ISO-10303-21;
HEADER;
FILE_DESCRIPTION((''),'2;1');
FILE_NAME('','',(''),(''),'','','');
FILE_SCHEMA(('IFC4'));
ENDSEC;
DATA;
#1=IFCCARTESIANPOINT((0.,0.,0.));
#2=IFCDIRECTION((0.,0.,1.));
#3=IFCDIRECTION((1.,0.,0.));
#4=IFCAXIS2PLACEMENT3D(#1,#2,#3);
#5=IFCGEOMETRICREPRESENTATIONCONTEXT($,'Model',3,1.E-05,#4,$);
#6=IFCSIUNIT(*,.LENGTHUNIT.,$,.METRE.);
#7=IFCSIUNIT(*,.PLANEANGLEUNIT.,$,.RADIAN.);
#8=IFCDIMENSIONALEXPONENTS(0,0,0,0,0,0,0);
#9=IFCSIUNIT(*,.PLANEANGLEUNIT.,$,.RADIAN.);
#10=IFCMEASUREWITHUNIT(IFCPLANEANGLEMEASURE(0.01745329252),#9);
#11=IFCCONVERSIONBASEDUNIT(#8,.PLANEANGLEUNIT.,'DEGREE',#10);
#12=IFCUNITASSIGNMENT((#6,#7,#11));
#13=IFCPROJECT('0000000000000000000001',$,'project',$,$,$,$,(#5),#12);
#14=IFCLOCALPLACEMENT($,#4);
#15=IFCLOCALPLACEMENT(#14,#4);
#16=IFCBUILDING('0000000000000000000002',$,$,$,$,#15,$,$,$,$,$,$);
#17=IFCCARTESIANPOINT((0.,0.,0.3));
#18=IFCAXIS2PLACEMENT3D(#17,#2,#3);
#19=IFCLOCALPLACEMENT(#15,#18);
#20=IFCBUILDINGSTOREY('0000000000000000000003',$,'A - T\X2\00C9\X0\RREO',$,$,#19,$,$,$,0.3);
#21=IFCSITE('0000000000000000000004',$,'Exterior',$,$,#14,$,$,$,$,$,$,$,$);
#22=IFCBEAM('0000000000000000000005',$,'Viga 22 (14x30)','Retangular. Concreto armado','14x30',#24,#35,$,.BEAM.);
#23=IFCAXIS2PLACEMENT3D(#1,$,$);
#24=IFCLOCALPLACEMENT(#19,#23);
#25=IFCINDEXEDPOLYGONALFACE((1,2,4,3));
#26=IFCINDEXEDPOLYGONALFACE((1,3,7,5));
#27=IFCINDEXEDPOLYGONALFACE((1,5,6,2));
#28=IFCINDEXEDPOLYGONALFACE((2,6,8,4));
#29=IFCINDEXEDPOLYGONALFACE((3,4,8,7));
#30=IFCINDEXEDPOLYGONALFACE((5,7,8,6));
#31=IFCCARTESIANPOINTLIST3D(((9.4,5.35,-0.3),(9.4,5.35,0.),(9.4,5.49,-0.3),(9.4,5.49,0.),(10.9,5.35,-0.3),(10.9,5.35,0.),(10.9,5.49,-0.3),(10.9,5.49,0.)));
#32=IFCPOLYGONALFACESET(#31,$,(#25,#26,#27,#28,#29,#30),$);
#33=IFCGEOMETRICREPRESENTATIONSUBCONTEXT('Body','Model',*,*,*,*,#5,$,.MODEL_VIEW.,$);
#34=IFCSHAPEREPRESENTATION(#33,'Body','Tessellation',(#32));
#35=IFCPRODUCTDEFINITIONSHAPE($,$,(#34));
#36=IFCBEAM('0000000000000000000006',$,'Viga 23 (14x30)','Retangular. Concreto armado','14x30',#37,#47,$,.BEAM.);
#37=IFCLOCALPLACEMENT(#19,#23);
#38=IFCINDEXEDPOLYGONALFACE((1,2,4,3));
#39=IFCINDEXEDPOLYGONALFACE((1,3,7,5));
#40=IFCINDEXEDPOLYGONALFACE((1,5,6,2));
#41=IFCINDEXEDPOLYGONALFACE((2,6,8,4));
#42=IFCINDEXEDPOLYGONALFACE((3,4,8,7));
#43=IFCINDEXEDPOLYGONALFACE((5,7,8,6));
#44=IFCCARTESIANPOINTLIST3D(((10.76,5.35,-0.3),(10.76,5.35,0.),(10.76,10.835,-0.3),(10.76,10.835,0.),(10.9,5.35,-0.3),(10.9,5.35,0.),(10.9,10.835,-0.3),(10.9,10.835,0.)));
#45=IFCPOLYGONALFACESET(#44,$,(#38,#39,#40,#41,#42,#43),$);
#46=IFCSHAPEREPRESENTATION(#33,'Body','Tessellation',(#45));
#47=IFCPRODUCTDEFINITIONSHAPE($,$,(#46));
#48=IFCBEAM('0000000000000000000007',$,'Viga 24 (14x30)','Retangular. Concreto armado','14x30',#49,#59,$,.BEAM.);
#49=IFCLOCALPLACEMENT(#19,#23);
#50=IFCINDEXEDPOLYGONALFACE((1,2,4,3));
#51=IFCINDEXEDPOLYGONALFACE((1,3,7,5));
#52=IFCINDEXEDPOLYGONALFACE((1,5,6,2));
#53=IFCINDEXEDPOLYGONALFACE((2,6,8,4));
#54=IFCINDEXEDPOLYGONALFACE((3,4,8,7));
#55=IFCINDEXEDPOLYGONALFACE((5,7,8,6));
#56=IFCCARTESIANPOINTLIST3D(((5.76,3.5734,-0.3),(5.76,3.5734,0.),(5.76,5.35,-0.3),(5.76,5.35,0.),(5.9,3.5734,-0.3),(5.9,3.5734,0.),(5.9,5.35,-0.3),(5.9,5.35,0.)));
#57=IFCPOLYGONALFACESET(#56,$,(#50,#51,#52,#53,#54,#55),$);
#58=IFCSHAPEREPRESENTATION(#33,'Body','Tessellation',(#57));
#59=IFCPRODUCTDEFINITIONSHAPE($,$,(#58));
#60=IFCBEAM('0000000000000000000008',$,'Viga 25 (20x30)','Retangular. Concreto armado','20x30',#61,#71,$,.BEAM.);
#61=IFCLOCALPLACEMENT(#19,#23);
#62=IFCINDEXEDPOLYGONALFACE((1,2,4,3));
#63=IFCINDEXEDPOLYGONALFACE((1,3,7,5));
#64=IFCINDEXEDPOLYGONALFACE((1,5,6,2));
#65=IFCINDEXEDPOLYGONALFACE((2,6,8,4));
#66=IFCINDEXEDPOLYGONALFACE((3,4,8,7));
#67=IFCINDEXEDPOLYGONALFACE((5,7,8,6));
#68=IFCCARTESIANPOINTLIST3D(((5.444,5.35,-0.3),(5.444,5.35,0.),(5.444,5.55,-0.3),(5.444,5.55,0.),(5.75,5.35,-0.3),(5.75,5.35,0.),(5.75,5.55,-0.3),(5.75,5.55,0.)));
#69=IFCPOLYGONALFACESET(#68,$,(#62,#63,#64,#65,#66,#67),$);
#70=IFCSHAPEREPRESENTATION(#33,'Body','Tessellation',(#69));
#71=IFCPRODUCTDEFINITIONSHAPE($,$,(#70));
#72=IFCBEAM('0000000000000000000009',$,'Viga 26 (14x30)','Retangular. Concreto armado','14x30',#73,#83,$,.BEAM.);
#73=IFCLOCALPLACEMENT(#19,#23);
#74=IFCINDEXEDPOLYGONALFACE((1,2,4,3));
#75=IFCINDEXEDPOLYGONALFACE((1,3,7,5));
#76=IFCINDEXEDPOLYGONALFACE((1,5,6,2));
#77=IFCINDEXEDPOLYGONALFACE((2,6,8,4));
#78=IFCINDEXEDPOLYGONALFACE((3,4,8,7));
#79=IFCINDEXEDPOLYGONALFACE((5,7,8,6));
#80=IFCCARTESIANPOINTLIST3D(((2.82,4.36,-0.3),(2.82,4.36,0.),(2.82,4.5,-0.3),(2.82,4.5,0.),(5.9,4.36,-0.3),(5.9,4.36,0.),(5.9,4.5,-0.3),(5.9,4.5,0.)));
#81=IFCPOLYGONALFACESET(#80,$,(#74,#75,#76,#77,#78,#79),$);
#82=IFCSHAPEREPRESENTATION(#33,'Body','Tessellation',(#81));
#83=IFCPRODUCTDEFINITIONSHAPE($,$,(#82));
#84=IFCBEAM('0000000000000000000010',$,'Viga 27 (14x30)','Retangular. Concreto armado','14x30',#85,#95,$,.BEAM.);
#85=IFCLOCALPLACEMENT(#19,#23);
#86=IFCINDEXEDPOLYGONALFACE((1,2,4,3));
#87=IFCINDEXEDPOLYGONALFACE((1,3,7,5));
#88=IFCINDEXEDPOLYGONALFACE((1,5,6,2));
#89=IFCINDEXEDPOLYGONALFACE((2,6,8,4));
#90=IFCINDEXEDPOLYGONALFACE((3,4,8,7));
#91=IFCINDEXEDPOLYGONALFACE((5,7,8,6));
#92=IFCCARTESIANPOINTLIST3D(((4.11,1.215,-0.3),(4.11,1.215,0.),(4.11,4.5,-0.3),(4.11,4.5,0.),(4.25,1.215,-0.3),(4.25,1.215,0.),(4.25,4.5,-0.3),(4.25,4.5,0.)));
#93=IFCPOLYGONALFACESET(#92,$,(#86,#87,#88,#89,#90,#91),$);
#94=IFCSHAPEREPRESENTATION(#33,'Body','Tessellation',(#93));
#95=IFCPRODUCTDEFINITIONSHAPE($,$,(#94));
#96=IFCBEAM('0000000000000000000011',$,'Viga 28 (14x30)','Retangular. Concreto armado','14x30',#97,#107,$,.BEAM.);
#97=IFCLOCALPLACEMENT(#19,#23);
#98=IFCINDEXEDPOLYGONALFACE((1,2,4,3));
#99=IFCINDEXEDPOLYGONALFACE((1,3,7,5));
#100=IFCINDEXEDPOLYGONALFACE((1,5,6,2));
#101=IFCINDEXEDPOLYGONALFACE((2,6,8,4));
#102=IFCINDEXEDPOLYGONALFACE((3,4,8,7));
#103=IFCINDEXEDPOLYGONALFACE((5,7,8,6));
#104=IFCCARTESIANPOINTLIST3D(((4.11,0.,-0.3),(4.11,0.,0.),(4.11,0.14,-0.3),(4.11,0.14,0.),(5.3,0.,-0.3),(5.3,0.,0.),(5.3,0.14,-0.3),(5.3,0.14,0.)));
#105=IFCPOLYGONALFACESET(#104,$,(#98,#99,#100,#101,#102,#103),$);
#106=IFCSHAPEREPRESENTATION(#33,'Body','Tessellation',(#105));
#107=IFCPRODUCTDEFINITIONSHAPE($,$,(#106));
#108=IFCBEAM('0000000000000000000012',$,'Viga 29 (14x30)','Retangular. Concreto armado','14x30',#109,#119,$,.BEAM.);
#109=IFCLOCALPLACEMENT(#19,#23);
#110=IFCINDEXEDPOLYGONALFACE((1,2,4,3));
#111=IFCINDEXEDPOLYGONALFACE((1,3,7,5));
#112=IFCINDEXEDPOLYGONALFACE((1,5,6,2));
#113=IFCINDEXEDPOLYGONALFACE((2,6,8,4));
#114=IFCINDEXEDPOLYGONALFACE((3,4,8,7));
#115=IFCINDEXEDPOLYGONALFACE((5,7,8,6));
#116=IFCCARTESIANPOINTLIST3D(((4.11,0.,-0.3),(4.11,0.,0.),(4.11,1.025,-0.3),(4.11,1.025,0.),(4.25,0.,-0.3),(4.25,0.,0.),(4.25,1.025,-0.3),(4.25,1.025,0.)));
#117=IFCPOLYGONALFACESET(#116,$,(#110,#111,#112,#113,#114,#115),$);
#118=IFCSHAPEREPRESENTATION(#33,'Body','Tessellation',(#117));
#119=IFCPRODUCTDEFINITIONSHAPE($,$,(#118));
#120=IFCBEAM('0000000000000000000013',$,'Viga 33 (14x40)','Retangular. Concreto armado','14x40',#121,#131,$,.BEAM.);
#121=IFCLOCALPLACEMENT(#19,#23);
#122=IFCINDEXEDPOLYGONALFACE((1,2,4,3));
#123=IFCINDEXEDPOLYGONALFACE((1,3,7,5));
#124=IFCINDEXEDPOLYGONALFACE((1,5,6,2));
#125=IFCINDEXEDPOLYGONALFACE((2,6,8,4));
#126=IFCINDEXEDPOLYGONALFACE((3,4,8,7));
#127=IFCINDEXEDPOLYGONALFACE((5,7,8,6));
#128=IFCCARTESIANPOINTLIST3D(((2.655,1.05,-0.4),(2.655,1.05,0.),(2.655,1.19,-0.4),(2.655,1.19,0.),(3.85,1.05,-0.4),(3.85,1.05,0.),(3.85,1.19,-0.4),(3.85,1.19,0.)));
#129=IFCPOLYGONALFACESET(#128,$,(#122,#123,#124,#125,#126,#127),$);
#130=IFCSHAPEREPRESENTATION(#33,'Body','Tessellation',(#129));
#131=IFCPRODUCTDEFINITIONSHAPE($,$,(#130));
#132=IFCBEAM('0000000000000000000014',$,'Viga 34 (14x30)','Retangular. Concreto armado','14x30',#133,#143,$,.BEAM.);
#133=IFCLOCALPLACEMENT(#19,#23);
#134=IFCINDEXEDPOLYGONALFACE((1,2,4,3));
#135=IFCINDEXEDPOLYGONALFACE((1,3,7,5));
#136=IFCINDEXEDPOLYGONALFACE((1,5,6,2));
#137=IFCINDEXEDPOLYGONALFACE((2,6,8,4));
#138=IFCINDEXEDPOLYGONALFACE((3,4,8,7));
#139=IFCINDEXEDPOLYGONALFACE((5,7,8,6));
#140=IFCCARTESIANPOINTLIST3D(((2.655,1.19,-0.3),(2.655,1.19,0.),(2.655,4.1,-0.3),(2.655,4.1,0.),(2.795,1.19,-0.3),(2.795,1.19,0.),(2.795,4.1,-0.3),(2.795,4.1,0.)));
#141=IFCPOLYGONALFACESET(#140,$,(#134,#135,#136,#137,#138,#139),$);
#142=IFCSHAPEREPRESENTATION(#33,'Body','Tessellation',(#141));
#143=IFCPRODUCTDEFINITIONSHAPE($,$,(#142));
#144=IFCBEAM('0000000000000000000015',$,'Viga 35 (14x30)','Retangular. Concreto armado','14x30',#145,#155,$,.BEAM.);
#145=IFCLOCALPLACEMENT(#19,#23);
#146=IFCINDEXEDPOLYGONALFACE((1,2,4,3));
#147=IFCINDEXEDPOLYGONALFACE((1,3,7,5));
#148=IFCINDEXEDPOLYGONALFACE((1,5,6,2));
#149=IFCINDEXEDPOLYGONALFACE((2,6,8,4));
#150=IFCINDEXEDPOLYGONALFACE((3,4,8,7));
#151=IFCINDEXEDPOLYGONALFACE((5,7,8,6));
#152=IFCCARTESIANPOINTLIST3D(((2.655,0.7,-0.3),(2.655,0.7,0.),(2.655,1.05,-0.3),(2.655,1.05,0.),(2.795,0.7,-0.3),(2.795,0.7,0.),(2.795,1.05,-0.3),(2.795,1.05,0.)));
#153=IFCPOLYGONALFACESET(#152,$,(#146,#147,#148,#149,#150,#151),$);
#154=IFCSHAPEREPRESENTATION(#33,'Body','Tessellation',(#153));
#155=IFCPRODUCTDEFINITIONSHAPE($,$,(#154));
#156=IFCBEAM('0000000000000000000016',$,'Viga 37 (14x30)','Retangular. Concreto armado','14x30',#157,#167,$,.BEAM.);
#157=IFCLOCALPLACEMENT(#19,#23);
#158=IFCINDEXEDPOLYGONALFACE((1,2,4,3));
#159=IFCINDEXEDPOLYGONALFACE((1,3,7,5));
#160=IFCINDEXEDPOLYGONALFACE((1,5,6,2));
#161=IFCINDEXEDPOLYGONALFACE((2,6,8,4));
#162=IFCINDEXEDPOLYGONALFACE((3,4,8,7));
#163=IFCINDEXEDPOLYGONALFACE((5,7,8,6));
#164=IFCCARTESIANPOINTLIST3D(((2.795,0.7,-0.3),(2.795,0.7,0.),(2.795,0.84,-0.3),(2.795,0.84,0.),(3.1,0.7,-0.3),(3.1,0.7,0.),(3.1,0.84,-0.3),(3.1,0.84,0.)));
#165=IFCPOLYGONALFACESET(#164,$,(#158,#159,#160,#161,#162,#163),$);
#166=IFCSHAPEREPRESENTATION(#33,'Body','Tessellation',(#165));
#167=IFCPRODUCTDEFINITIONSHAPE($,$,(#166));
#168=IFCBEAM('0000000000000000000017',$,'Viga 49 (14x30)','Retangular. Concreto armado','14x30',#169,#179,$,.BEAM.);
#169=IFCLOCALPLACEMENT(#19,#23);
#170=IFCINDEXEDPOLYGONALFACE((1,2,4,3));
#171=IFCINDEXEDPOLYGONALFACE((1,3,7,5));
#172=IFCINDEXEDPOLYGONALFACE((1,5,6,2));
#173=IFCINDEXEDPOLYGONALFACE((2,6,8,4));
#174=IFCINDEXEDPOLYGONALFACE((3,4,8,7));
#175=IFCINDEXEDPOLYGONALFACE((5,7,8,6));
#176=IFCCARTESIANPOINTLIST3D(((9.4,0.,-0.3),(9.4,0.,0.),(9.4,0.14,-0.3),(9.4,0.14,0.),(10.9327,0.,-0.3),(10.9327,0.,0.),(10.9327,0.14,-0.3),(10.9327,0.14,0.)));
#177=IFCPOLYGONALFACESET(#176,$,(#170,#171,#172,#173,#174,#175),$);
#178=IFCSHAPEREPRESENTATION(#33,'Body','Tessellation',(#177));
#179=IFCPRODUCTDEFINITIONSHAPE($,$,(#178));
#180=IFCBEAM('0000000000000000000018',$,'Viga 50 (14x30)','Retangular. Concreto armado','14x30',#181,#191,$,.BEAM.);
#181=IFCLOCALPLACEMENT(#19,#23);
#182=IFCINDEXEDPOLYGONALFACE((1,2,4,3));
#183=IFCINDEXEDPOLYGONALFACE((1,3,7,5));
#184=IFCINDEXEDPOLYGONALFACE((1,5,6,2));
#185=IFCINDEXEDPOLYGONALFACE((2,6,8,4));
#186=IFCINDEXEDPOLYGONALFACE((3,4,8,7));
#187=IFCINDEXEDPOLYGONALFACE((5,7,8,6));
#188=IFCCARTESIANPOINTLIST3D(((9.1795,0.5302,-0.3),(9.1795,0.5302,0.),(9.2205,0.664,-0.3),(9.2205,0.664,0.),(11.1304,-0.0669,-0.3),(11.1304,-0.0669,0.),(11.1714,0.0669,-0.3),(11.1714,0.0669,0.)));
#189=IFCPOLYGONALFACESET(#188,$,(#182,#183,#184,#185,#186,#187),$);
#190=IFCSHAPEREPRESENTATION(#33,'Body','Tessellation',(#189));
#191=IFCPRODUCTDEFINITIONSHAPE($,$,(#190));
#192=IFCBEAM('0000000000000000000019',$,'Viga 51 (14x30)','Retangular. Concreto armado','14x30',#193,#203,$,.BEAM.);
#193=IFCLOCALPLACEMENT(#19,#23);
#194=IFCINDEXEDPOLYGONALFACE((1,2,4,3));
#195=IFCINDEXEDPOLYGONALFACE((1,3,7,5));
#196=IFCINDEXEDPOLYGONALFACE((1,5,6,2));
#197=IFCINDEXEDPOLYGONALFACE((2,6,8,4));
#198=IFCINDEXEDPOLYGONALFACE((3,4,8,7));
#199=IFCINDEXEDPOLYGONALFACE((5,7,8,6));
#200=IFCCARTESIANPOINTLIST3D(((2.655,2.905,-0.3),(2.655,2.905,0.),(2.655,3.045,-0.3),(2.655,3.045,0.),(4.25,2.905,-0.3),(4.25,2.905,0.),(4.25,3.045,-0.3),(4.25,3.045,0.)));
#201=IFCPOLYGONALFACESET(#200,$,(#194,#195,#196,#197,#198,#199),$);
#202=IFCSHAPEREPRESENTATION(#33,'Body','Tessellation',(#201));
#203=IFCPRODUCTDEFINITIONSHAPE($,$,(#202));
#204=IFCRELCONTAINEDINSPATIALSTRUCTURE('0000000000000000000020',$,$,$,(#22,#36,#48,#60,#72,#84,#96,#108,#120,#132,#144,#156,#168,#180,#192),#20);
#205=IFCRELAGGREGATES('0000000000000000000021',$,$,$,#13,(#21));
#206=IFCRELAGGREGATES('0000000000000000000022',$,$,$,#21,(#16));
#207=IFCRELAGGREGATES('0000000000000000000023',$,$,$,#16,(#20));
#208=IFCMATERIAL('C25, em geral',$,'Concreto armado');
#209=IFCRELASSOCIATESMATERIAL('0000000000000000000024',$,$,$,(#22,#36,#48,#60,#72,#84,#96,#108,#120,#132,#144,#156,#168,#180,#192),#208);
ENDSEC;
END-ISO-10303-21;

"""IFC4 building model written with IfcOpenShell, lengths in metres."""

from ifc_helpers import new_model, entity, si_unit, converted_unit, frame, frame_2d, origin_with_axes, place, context, subcontext, project, spatial, rectangle, extrude, material, element, save


model = new_model("IFC4")

# Units and contexts
model_context = context("Model", 3, precision=1e-05, world=origin_with_axes())
body_context = subcontext(model_context, "Body", "Model", "MODEL_VIEW")
ifc_project = project(units=[si_unit("LENGTHUNIT", "METRE"), si_unit("PLANEANGLEUNIT", "RADIAN"), converted_unit("PLANEANGLEUNIT", "DEGREE", entity("IfcPlaneAngleMeasure", 0.01745329252), si_unit("PLANEANGLEUNIT", "RADIAN"), dimensions=[0, 0, 0, 0, 0, 0, 0])], contexts=[model_context])

# Site, building, storey
site_placement = place(None, origin_with_axes())
site = spatial("IfcSite", under=ifc_project, at=site_placement, Name="Exterior")
building_placement = place(site_placement, origin_with_axes())
building = spatial("IfcBuilding", under=site, at=building_placement)
storey_placement = place(building_placement, frame((0.0, 0.0, 0.3), z_axis=(0.0, 0.0, 1.0), x_axis=(1.0, 0.0, 0.0)))
storey = spatial("IfcBuildingStorey", under=building, at=storey_placement, Name="A - TÉRREO", Elevation=0.3)

# Shared definitions
ifc_material = material(Name="C25, em geral", Category="Concreto armado")

# Beams
beam_1_placement = place(storey_placement, frame((9.4, 5.42, 0.0), z_axis=(1.0, 0.0, 0.0), x_axis=(0.0, 1.0, 0.0)))
element("IfcBeam", 1, at=beam_1_placement, inside=storey, material=ifc_material, Name="Viga 22 (14x30)", Description="Retangular. Concreto armado", ObjectType="14x30", PredefinedType="BEAM", context=body_context, shape_type="SweptSolid", body=[
    extrude(rectangle(XDim=0.14, YDim=0.3, at=frame_2d((0.0, -0.15), x_axis=(1.0, 0.0))), origin_with_axes(), (0.0, 0.0, 1.0), 1.5),
])
beam_2_placement = place(storey_placement, frame((10.83, 5.35, 0.0), z_axis=(0.0, 1.0, 0.0), x_axis=(-1.0, 0.0, 0.0)))
element("IfcBeam", 2, at=beam_2_placement, inside=storey, material=ifc_material, Name="Viga 23 (14x30)", Description="Retangular. Concreto armado", ObjectType="14x30", PredefinedType="BEAM", context=body_context, shape_type="SweptSolid", body=[
    extrude(rectangle(XDim=0.14, YDim=0.3, at=frame_2d((0.0, -0.15), x_axis=(1.0, 0.0))), origin_with_axes(), (0.0, 0.0, 1.0), 5.485),
])
beam_3_placement = place(storey_placement, frame((5.83, 3.5734, 0.0), z_axis=(0.0, 1.0, 0.0), x_axis=(-1.0, 0.0, 0.0)))
element("IfcBeam", 3, at=beam_3_placement, inside=storey, material=ifc_material, Name="Viga 24 (14x30)", Description="Retangular. Concreto armado", ObjectType="14x30", PredefinedType="BEAM", context=body_context, shape_type="SweptSolid", body=[
    extrude(rectangle(XDim=0.14, YDim=0.3, at=frame_2d((0.0, -0.15), x_axis=(1.0, 0.0))), origin_with_axes(), (0.0, 0.0, 1.0), 1.7766),
])
beam_4_placement = place(storey_placement, frame((5.444, 5.45, 0.0), z_axis=(1.0, 0.0, 0.0), x_axis=(0.0, 1.0, 0.0)))
element("IfcBeam", 4, at=beam_4_placement, inside=storey, material=ifc_material, Name="Viga 25 (20x30)", Description="Retangular. Concreto armado", ObjectType="20x30", PredefinedType="BEAM", context=body_context, shape_type="SweptSolid", body=[
    extrude(rectangle(XDim=0.2, YDim=0.3, at=frame_2d((0.0, -0.15), x_axis=(1.0, 0.0))), origin_with_axes(), (0.0, 0.0, 1.0), 0.306),
])
beam_5_placement = place(storey_placement, frame((2.82, 4.43, 0.0), z_axis=(1.0, 0.0, 0.0), x_axis=(0.0, 1.0, 0.0)))
element("IfcBeam", 5, at=beam_5_placement, inside=storey, material=ifc_material, Name="Viga 26 (14x30)", Description="Retangular. Concreto armado", ObjectType="14x30", PredefinedType="BEAM", context=body_context, shape_type="SweptSolid", body=[
    extrude(rectangle(XDim=0.14, YDim=0.3, at=frame_2d((0.0, -0.15), x_axis=(1.0, 0.0))), origin_with_axes(), (0.0, 0.0, 1.0), 3.08),
])
beam_6_placement = place(storey_placement, frame((4.18, 1.215, 0.0), z_axis=(0.0, 1.0, 0.0), x_axis=(-1.0, 0.0, 0.0)))
element("IfcBeam", 6, at=beam_6_placement, inside=storey, material=ifc_material, Name="Viga 27 (14x30)", Description="Retangular. Concreto armado", ObjectType="14x30", PredefinedType="BEAM", context=body_context, shape_type="SweptSolid", body=[
    extrude(rectangle(XDim=0.14, YDim=0.3, at=frame_2d((0.0, -0.15), x_axis=(1.0, 0.0))), origin_with_axes(), (0.0, 0.0, 1.0), 3.285),
])
beam_7_placement = place(storey_placement, frame((4.11, 0.07, 0.0), z_axis=(1.0, 0.0, 0.0), x_axis=(0.0, 1.0, 0.0)))
element("IfcBeam", 7, at=beam_7_placement, inside=storey, material=ifc_material, Name="Viga 28 (14x30)", Description="Retangular. Concreto armado", ObjectType="14x30", PredefinedType="BEAM", context=body_context, shape_type="SweptSolid", body=[
    extrude(rectangle(XDim=0.14, YDim=0.3, at=frame_2d((0.0, -0.15), x_axis=(1.0, 0.0))), origin_with_axes(), (0.0, 0.0, 1.0), 1.19),
])
beam_8_placement = place(storey_placement, frame((4.18, 0.0, 0.0), z_axis=(0.0, 1.0, 0.0), x_axis=(-1.0, 0.0, 0.0)))
element("IfcBeam", 8, at=beam_8_placement, inside=storey, material=ifc_material, Name="Viga 29 (14x30)", Description="Retangular. Concreto armado", ObjectType="14x30", PredefinedType="BEAM", context=body_context, shape_type="SweptSolid", body=[
    extrude(rectangle(XDim=0.14, YDim=0.3, at=frame_2d((0.0, -0.15), x_axis=(1.0, 0.0))), origin_with_axes(), (0.0, 0.0, 1.0), 1.025),
])
beam_9_placement = place(storey_placement, frame((3.85, 1.12, 0.0), z_axis=(-1.0, 0.0, 0.0), x_axis=(0.0, -1.0, 0.0)))
element("IfcBeam", 9, at=beam_9_placement, inside=storey, material=ifc_material, Name="Viga 33 (14x40)", Description="Retangular. Concreto armado", ObjectType="14x40", PredefinedType="BEAM", context=body_context, shape_type="SweptSolid", body=[
    extrude(rectangle(XDim=0.14, YDim=0.4, at=frame_2d((0.0, -0.2), x_axis=(1.0, 0.0))), origin_with_axes(), (0.0, 0.0, 1.0), 1.195),
])
beam_10_placement = place(storey_placement, frame((2.725, 4.1, 0.0), z_axis=(0.0, -1.0, 0.0), x_axis=(1.0, 0.0, 0.0)))
element("IfcBeam", 10, at=beam_10_placement, inside=storey, material=ifc_material, Name="Viga 34 (14x30)", Description="Retangular. Concreto armado", ObjectType="14x30", PredefinedType="BEAM", context=body_context, shape_type="SweptSolid", body=[
    extrude(rectangle(XDim=0.14, YDim=0.3, at=frame_2d((0.0, -0.15), x_axis=(1.0, 0.0))), origin_with_axes(), (0.0, 0.0, 1.0), 2.91),
])
beam_11_placement = place(storey_placement, frame((2.725, 1.05, 0.0), z_axis=(0.0, -1.0, 0.0), x_axis=(1.0, 0.0, 0.0)))
element("IfcBeam", 11, at=beam_11_placement, inside=storey, material=ifc_material, Name="Viga 35 (14x30)", Description="Retangular. Concreto armado", ObjectType="14x30", PredefinedType="BEAM", context=body_context, shape_type="SweptSolid", body=[
    extrude(rectangle(XDim=0.14, YDim=0.3, at=frame_2d((0.0, -0.15), x_axis=(1.0, 0.0))), origin_with_axes(), (0.0, 0.0, 1.0), 0.35),
])
beam_12_placement = place(storey_placement, frame((3.1, 0.77, 0.0), z_axis=(-1.0, 0.0, 0.0), x_axis=(0.0, -1.0, 0.0)))
element("IfcBeam", 12, at=beam_12_placement, inside=storey, material=ifc_material, Name="Viga 37 (14x30)", Description="Retangular. Concreto armado", ObjectType="14x30", PredefinedType="BEAM", context=body_context, shape_type="SweptSolid", body=[
    extrude(rectangle(XDim=0.14, YDim=0.3, at=frame_2d((0.0, -0.15), x_axis=(1.0, 0.0))), origin_with_axes(), (0.0, 0.0, 1.0), 0.305),
])
beam_13_placement = place(storey_placement, frame((9.4, 0.07, 0.0), z_axis=(1.0, 0.0, 0.0), x_axis=(0.0, 1.0, 0.0)))
element("IfcBeam", 13, at=beam_13_placement, inside=storey, material=ifc_material, Name="Viga 49 (14x30)", Description="Retangular. Concreto armado", ObjectType="14x30", PredefinedType="BEAM", context=body_context, shape_type="SweptSolid", body=[
    extrude(rectangle(XDim=0.14, YDim=0.3, at=frame_2d((0.0, -0.15), x_axis=(1.0, 0.0))), origin_with_axes(), (0.0, 0.0, 1.0), 1.5327),
])
beam_14_placement = place(storey_placement, frame((11.1509, 0.0, 0.0), z_axis=(-0.956217, 0.29266, 0.0), x_axis=(-0.29266, -0.956217, 0.0)))
element("IfcBeam", 14, at=beam_14_placement, inside=storey, material=ifc_material, Name="Viga 50 (14x30)", Description="Retangular. Concreto armado", ObjectType="14x30", PredefinedType="BEAM", context=body_context, shape_type="SweptSolid", body=[
    extrude(rectangle(XDim=0.14, YDim=0.3, at=frame_2d((0.0, -0.15), x_axis=(1.0, 0.0))), origin_with_axes(), (0.0, 0.0, 1.0), 2.0402),
])
beam_15_placement = place(storey_placement, frame((4.25, 2.975, 0.0), z_axis=(-1.0, 0.0, 0.0), x_axis=(0.0, -1.0, 0.0)))
element("IfcBeam", 15, at=beam_15_placement, inside=storey, material=ifc_material, Name="Viga 51 (14x30)", Description="Retangular. Concreto armado", ObjectType="14x30", PredefinedType="BEAM", context=body_context, shape_type="SweptSolid", body=[
    extrude(rectangle(XDim=0.14, YDim=0.3, at=frame_2d((0.0, -0.15), x_axis=(1.0, 0.0))), origin_with_axes(), (0.0, 0.0, 1.0), 1.595),
])

save(model, "model.ifc")
